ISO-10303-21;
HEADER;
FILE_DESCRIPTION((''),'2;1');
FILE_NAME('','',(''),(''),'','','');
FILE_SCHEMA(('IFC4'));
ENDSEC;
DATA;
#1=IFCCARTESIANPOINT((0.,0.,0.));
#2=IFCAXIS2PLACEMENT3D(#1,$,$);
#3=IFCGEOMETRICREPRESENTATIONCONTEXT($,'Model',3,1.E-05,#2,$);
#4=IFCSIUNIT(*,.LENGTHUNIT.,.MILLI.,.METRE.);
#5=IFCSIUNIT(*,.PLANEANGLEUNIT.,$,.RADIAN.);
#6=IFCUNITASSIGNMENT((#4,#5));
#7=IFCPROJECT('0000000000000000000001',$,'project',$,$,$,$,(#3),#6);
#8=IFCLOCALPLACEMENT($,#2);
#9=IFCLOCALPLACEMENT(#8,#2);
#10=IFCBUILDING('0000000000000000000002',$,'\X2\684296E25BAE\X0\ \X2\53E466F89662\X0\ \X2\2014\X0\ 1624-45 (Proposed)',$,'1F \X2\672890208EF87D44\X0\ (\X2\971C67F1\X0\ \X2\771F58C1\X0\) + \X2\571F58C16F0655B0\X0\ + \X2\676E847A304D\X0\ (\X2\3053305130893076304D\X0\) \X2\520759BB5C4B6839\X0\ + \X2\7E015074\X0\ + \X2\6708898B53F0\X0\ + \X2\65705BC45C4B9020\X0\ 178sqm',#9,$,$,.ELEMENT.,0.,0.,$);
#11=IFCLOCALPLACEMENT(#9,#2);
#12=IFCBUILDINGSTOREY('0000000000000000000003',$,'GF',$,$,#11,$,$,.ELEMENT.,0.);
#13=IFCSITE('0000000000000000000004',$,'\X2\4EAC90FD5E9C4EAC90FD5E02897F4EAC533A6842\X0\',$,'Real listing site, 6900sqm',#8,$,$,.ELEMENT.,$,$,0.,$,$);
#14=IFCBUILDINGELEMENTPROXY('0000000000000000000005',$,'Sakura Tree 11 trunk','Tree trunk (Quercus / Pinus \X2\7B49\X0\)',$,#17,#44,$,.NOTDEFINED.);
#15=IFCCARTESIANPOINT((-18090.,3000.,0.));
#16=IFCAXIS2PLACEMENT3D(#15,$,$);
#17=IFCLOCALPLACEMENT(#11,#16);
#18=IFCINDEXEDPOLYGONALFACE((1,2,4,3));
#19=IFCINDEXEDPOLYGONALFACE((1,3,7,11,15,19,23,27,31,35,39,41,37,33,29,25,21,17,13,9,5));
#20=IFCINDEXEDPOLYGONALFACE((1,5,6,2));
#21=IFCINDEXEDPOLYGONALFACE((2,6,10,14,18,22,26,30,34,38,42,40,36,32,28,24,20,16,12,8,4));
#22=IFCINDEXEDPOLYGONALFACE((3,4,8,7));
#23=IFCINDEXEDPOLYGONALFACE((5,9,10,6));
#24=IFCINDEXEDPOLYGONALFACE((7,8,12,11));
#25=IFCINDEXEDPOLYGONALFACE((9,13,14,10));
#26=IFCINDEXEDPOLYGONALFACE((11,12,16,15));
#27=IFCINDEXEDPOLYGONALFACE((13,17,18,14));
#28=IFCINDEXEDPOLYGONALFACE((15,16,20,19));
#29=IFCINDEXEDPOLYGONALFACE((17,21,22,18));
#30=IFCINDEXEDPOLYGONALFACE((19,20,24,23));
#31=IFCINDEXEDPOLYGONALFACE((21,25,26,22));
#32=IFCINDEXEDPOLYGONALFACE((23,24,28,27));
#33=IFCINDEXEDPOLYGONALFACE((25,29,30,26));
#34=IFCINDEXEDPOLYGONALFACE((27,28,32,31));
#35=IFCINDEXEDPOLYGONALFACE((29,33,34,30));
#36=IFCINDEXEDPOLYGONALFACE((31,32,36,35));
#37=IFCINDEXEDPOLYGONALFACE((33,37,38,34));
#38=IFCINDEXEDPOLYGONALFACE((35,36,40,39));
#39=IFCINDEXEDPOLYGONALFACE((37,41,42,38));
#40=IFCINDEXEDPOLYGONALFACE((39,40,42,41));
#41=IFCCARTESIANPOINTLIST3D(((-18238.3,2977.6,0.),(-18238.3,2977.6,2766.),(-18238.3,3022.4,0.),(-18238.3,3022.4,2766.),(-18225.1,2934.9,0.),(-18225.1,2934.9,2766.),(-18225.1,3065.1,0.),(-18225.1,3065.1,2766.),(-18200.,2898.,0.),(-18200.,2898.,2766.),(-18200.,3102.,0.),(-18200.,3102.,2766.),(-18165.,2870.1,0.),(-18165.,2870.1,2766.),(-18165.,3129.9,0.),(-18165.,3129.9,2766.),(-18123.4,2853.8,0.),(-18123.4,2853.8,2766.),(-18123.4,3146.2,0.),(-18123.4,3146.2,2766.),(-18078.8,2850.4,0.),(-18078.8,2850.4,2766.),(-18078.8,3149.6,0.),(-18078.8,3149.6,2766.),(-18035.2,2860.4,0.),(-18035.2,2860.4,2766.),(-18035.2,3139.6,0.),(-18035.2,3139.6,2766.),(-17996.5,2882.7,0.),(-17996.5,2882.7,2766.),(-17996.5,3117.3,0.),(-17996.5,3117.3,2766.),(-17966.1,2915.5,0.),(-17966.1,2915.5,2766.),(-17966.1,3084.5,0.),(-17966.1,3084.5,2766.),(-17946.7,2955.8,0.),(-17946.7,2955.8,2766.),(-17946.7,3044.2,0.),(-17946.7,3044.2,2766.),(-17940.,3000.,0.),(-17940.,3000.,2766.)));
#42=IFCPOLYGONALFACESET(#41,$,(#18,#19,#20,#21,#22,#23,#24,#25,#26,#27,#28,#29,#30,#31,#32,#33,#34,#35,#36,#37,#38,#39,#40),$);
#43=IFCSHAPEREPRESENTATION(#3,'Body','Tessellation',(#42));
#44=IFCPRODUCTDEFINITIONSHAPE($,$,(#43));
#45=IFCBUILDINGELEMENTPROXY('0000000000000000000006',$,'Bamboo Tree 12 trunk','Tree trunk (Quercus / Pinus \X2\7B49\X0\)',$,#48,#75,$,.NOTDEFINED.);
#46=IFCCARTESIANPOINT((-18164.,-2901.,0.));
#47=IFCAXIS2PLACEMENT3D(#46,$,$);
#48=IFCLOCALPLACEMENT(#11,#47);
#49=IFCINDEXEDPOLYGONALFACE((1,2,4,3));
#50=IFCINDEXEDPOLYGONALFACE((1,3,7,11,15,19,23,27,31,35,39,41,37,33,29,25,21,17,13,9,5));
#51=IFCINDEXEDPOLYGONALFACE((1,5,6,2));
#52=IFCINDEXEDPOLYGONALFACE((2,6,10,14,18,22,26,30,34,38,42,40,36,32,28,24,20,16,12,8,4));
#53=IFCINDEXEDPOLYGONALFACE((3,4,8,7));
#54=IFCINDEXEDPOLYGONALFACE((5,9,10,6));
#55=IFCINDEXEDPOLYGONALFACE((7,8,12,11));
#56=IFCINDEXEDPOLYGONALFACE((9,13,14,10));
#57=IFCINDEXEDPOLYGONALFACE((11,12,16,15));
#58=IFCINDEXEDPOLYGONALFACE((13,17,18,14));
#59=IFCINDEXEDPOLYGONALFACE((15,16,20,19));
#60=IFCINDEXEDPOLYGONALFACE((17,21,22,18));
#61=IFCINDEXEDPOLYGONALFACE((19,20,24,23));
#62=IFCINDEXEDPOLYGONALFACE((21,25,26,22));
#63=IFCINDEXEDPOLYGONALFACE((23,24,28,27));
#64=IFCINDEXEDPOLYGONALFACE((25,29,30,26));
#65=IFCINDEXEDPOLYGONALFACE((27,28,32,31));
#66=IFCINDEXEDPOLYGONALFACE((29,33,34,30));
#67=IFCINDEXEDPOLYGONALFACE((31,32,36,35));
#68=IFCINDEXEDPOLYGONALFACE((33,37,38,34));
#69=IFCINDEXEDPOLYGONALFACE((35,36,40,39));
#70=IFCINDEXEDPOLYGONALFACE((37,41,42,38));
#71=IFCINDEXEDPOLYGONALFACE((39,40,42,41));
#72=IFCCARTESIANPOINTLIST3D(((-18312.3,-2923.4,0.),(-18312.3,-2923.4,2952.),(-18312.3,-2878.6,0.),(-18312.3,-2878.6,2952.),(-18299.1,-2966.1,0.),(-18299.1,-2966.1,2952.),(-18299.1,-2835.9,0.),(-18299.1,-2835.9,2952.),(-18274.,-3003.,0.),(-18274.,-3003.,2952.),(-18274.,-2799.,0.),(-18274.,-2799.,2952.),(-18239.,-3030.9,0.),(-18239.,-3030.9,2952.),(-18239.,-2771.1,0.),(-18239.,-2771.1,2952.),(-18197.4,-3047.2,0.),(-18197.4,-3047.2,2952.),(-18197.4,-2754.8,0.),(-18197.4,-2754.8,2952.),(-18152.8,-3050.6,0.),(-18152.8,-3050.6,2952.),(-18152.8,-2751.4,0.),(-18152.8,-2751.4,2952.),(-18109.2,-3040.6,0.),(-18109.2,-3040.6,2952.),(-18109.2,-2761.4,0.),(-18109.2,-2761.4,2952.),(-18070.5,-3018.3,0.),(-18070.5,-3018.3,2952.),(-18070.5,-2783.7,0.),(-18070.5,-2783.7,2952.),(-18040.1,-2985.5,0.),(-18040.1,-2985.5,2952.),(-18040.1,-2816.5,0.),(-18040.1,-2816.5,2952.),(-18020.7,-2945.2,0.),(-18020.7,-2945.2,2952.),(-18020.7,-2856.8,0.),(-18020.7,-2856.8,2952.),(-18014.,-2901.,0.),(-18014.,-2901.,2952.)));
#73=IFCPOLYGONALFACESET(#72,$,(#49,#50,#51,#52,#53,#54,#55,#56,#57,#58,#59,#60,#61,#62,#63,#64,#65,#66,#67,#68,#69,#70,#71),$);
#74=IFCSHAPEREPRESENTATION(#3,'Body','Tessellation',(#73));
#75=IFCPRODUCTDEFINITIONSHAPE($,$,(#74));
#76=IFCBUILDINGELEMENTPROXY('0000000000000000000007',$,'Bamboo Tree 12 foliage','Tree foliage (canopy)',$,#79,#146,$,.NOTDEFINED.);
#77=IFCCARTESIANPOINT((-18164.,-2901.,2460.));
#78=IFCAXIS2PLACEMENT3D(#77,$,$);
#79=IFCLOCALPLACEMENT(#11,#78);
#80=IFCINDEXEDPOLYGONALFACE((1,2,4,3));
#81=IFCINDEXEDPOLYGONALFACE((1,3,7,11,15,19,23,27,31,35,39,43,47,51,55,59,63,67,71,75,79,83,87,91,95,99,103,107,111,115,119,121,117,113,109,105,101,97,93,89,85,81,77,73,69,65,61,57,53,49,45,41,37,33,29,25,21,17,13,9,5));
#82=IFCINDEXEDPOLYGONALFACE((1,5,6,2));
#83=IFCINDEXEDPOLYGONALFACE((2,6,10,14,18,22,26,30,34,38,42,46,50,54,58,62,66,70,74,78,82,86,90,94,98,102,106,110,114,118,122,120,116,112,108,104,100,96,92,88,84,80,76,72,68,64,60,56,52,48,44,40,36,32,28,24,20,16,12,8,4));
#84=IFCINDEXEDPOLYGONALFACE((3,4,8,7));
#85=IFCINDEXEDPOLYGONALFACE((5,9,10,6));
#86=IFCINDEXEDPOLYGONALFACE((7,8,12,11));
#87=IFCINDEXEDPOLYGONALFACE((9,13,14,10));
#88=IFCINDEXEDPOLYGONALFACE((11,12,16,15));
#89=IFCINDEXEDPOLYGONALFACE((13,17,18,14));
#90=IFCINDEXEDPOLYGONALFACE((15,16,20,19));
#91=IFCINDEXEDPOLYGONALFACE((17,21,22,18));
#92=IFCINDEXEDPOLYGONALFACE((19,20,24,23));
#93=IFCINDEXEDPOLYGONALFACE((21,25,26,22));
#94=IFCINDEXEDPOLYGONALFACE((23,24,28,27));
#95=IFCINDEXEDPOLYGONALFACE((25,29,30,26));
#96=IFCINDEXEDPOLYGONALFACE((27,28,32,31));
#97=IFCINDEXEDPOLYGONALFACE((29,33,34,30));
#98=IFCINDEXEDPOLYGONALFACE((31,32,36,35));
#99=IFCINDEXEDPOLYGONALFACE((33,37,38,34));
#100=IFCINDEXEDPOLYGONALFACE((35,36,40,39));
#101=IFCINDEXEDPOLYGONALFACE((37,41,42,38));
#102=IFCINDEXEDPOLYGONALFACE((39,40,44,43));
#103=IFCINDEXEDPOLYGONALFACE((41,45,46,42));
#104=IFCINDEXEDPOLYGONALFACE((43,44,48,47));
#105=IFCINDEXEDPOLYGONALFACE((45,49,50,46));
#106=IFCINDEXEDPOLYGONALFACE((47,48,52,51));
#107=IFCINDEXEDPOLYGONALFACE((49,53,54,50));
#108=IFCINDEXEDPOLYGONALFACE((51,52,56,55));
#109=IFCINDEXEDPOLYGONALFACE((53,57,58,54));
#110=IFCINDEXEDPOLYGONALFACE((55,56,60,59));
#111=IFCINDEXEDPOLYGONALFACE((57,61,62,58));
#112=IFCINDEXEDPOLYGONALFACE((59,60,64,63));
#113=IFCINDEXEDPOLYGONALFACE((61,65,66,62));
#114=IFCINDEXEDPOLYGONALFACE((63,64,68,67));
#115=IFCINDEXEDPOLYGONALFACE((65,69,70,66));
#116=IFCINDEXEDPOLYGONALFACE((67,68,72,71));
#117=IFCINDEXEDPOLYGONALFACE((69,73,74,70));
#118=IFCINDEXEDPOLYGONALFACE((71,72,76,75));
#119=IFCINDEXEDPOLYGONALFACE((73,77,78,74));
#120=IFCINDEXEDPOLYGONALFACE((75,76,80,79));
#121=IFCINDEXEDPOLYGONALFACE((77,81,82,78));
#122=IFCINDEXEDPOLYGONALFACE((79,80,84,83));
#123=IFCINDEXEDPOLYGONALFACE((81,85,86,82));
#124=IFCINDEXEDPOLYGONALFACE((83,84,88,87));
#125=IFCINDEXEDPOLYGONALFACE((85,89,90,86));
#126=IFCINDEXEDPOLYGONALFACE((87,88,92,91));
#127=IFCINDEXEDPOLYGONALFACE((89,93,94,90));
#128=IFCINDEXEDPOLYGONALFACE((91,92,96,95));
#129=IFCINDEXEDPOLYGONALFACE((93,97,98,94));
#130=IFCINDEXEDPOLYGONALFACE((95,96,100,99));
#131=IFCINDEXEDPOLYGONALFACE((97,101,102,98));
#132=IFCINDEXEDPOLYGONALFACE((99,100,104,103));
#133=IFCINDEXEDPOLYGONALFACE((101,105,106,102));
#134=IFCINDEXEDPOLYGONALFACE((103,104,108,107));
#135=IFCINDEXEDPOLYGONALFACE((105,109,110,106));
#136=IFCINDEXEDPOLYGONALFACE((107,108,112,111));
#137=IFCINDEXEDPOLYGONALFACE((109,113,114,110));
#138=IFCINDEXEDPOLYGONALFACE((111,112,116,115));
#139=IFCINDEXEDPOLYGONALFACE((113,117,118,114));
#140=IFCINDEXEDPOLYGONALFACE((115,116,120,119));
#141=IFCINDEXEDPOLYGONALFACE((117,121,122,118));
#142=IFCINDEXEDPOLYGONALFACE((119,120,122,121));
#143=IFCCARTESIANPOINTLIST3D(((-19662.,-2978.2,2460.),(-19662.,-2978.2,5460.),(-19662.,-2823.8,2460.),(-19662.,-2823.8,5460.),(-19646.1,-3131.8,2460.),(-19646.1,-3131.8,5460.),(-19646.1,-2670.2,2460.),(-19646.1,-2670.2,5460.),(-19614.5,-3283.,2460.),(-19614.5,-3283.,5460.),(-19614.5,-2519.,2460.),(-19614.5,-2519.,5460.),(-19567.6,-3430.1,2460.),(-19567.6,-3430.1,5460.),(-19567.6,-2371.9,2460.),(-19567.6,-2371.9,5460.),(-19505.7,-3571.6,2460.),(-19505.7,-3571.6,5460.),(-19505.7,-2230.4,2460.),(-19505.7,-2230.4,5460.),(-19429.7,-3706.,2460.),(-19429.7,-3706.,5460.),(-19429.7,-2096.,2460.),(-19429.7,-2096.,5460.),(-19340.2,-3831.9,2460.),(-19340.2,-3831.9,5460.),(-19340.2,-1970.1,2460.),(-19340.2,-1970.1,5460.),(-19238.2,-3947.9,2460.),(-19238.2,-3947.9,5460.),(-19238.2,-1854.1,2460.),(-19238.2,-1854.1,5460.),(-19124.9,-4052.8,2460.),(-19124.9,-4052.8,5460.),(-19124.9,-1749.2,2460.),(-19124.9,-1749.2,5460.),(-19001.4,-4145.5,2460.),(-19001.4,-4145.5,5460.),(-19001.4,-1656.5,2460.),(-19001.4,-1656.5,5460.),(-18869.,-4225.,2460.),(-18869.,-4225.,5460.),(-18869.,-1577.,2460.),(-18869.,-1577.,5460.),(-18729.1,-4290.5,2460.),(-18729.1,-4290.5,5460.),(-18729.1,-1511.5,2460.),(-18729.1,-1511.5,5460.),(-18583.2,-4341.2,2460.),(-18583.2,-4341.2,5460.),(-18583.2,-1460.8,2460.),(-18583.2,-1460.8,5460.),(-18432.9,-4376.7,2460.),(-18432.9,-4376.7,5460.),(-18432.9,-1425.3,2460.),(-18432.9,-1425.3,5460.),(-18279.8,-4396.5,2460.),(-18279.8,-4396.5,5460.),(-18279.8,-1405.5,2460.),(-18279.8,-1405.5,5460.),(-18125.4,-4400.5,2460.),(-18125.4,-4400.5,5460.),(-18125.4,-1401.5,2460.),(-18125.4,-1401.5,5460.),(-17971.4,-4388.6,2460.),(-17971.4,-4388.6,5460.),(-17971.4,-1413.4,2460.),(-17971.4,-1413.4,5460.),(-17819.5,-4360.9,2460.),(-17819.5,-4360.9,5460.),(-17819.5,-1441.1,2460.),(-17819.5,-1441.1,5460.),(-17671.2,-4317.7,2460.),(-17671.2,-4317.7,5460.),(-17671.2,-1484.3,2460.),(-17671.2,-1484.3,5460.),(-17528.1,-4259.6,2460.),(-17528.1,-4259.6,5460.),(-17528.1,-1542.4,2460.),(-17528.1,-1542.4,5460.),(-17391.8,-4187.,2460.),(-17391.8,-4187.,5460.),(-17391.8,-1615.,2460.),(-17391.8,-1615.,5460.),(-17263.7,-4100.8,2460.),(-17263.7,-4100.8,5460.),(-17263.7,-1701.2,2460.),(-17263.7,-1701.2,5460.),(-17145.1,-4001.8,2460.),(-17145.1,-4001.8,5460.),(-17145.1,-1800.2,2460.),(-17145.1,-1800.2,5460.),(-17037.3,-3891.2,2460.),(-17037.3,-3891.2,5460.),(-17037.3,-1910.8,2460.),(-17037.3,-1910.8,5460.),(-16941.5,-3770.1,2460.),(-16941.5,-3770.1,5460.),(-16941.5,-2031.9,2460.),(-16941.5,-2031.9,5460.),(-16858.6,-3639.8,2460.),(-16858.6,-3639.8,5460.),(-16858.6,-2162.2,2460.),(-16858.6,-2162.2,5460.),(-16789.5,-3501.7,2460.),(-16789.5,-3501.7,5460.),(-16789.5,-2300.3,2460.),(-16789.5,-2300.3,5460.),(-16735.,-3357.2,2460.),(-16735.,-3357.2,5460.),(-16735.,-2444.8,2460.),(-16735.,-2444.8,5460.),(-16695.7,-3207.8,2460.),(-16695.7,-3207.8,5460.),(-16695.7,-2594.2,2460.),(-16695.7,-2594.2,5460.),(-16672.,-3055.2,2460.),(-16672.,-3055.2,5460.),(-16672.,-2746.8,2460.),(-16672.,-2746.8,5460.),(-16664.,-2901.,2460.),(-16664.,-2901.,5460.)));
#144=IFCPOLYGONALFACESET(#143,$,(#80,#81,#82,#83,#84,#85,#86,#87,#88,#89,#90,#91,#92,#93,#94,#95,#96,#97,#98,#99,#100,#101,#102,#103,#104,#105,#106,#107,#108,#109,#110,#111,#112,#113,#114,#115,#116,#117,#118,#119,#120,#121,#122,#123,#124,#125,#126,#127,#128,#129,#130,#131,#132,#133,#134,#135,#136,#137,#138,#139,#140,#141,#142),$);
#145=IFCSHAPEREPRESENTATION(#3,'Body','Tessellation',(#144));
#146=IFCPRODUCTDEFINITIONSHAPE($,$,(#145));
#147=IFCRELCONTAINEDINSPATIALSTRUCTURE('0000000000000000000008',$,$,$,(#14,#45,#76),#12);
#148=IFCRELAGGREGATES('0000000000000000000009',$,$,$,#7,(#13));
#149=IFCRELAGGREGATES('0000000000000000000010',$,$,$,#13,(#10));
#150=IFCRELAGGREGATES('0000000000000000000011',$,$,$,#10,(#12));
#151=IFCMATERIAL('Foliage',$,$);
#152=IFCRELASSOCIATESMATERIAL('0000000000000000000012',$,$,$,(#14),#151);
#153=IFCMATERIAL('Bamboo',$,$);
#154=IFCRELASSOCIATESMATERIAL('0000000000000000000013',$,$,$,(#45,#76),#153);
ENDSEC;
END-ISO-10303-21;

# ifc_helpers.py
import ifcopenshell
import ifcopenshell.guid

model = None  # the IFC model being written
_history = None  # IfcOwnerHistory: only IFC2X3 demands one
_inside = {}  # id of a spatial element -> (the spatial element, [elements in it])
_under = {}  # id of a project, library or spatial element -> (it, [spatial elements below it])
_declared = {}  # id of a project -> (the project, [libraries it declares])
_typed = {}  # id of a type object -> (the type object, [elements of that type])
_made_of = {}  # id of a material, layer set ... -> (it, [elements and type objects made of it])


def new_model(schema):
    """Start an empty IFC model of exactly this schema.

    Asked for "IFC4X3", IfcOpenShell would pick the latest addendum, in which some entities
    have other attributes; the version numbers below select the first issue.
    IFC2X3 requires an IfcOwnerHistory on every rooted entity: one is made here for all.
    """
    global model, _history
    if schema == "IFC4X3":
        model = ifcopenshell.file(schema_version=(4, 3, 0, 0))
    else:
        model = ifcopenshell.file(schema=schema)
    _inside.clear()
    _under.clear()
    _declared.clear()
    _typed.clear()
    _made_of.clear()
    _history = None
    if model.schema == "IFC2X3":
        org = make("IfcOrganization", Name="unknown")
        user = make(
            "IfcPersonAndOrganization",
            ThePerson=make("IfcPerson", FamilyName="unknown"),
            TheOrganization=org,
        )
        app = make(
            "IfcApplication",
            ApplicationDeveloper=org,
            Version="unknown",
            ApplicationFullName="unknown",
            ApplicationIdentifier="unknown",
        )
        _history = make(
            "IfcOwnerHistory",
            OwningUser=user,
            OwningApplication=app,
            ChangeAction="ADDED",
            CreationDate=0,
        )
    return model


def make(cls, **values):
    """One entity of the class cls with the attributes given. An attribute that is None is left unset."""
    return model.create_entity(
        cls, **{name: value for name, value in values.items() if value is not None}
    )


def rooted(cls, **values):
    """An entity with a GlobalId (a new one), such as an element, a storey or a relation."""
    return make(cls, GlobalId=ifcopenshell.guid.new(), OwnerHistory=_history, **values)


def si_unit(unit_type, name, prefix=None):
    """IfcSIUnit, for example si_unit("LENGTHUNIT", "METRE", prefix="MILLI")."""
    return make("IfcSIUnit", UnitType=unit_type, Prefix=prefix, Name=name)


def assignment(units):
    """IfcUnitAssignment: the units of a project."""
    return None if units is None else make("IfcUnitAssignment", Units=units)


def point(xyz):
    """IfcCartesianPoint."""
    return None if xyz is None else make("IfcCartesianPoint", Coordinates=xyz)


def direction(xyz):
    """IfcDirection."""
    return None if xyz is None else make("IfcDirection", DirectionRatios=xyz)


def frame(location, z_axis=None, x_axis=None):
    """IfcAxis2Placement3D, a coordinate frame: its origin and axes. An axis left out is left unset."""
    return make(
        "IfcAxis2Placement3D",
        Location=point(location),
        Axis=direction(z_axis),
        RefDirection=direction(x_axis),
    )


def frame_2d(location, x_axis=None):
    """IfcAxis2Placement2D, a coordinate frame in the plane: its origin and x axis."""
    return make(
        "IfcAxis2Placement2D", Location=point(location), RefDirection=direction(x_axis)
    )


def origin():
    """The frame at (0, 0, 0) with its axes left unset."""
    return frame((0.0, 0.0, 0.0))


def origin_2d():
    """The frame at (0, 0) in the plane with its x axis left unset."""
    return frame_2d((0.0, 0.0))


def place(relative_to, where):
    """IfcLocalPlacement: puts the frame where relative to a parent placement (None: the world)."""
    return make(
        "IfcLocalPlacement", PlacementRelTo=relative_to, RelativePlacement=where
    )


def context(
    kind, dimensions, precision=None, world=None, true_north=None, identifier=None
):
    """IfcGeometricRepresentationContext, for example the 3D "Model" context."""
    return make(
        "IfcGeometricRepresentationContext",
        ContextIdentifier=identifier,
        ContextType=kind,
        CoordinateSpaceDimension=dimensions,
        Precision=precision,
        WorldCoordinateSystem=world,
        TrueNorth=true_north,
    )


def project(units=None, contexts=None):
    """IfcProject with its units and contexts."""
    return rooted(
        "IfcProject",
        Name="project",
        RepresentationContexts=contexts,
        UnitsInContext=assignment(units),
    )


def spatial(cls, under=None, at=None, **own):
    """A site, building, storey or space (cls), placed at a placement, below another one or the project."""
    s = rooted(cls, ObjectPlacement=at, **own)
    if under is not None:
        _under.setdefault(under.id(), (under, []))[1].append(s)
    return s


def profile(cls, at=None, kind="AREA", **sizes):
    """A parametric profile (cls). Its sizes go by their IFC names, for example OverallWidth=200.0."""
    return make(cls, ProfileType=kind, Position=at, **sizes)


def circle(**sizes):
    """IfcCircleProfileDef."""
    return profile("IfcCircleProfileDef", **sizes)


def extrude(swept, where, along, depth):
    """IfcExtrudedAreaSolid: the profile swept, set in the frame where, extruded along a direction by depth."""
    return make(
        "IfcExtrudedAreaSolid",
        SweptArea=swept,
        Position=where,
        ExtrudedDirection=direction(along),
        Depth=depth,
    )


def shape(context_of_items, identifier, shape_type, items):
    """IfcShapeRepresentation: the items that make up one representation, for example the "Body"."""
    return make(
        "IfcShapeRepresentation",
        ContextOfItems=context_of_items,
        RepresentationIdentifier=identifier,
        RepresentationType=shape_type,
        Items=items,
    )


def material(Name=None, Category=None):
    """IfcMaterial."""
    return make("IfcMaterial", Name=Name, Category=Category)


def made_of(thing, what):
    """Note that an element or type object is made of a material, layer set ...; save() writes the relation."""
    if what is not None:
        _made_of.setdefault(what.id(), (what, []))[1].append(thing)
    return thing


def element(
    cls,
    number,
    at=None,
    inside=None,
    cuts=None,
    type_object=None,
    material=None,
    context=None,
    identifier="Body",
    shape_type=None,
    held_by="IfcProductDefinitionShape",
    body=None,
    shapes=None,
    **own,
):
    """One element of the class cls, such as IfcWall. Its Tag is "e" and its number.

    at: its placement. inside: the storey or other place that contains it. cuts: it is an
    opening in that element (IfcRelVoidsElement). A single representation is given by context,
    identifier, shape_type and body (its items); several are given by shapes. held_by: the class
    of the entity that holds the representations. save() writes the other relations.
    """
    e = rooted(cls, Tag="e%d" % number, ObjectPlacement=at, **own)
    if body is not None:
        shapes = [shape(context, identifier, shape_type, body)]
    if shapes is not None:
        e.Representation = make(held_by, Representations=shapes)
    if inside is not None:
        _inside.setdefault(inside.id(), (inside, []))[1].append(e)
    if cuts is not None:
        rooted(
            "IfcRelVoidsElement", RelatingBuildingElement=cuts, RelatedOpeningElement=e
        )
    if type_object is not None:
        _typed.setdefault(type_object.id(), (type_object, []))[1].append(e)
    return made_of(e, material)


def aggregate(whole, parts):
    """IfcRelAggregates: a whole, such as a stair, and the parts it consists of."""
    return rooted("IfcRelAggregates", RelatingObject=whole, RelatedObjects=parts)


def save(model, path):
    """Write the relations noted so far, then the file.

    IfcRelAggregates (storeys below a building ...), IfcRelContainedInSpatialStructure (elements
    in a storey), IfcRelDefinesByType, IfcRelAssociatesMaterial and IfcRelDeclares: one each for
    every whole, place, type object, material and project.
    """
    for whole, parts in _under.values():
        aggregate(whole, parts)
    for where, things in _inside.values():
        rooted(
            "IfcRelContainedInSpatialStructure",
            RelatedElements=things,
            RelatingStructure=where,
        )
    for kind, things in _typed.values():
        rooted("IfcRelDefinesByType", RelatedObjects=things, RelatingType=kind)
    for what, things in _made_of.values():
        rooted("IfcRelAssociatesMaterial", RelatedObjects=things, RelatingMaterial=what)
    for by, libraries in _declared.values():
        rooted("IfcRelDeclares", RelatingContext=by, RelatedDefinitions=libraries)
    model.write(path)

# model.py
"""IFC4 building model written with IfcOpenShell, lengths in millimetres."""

from ifc_helpers import new_model, si_unit, frame, origin, origin_2d, place, context, project, spatial, circle, extrude, material, element, save


model = new_model("IFC4")

# Units and contexts
model_context = context("Model", 3, precision=1e-05, world=origin())
ifc_project = project(units=[si_unit("LENGTHUNIT", "METRE", prefix="MILLI"), si_unit("PLANEANGLEUNIT", "RADIAN")], contexts=[model_context])

# Site, building, storey
site_placement = place(None, origin())
site = spatial("IfcSite", under=ifc_project, at=site_placement, Name="京都府京都市西京区桂", ObjectType="Real listing site, 6900sqm", CompositionType="ELEMENT", RefElevation=0.0)
building_placement = place(site_placement, origin())
building = spatial("IfcBuilding", under=site, at=building_placement, Name="桂離宮 古書院 — 1624-45 (Proposed)", ObjectType="1F 木造軸組 (霜柱 真壁) + 土壁漆喰 + 杮葺き (こけらぶき) 切妻屋根 + 縁側 + 月見台 + 数寄屋造 178sqm", CompositionType="ELEMENT", ElevationOfRefHeight=0.0, ElevationOfTerrain=0.0)
storey_placement = place(building_placement, origin())
storey = spatial("IfcBuildingStorey", under=building, at=storey_placement, Name="GF", CompositionType="ELEMENT", Elevation=0.0)

# Building element proxies
ifc_material_1 = material(Name="Foliage")
ifc_material_2 = material(Name="Bamboo")
proxy_1_placement = place(storey_placement, frame((-18090.0, 3000.0, 0.0)))
element("IfcBuildingElementProxy", 1, at=proxy_1_placement, inside=storey, material=ifc_material_1, Name="Sakura Tree 11 trunk", Description="Tree trunk (Quercus / Pinus 等)", PredefinedType="NOTDEFINED", context=model_context, shape_type="SweptSolid", body=[
    extrude(circle(Radius=150.0, at=origin_2d()), frame((-18090.0, 3000.0, 0.0)), (0.0, 0.0, 1.0), 2766.0),
])
proxy_2_placement = place(storey_placement, frame((-18164.0, -2901.0, 0.0)))
element("IfcBuildingElementProxy", 2, at=proxy_2_placement, inside=storey, material=ifc_material_2, Name="Bamboo Tree 12 trunk", Description="Tree trunk (Quercus / Pinus 等)", PredefinedType="NOTDEFINED", context=model_context, shape_type="SweptSolid", body=[
    extrude(circle(Radius=150.0, at=origin_2d()), frame((-18164.0, -2901.0, 0.0)), (0.0, 0.0, 1.0), 2952.0),
])
proxy_3_placement = place(storey_placement, frame((-18164.0, -2901.0, 2460.0)))
element("IfcBuildingElementProxy", 3, at=proxy_3_placement, inside=storey, material=ifc_material_2, Name="Bamboo Tree 12 foliage", Description="Tree foliage (canopy)", PredefinedType="NOTDEFINED", context=model_context, shape_type="SweptSolid", body=[
    extrude(circle(Radius=1500.0, at=origin_2d()), frame((-18164.0, -2901.0, 2460.0)), (0.0, 0.0, 1.0), 3000.0),
])

save(model, "model.ifc")
